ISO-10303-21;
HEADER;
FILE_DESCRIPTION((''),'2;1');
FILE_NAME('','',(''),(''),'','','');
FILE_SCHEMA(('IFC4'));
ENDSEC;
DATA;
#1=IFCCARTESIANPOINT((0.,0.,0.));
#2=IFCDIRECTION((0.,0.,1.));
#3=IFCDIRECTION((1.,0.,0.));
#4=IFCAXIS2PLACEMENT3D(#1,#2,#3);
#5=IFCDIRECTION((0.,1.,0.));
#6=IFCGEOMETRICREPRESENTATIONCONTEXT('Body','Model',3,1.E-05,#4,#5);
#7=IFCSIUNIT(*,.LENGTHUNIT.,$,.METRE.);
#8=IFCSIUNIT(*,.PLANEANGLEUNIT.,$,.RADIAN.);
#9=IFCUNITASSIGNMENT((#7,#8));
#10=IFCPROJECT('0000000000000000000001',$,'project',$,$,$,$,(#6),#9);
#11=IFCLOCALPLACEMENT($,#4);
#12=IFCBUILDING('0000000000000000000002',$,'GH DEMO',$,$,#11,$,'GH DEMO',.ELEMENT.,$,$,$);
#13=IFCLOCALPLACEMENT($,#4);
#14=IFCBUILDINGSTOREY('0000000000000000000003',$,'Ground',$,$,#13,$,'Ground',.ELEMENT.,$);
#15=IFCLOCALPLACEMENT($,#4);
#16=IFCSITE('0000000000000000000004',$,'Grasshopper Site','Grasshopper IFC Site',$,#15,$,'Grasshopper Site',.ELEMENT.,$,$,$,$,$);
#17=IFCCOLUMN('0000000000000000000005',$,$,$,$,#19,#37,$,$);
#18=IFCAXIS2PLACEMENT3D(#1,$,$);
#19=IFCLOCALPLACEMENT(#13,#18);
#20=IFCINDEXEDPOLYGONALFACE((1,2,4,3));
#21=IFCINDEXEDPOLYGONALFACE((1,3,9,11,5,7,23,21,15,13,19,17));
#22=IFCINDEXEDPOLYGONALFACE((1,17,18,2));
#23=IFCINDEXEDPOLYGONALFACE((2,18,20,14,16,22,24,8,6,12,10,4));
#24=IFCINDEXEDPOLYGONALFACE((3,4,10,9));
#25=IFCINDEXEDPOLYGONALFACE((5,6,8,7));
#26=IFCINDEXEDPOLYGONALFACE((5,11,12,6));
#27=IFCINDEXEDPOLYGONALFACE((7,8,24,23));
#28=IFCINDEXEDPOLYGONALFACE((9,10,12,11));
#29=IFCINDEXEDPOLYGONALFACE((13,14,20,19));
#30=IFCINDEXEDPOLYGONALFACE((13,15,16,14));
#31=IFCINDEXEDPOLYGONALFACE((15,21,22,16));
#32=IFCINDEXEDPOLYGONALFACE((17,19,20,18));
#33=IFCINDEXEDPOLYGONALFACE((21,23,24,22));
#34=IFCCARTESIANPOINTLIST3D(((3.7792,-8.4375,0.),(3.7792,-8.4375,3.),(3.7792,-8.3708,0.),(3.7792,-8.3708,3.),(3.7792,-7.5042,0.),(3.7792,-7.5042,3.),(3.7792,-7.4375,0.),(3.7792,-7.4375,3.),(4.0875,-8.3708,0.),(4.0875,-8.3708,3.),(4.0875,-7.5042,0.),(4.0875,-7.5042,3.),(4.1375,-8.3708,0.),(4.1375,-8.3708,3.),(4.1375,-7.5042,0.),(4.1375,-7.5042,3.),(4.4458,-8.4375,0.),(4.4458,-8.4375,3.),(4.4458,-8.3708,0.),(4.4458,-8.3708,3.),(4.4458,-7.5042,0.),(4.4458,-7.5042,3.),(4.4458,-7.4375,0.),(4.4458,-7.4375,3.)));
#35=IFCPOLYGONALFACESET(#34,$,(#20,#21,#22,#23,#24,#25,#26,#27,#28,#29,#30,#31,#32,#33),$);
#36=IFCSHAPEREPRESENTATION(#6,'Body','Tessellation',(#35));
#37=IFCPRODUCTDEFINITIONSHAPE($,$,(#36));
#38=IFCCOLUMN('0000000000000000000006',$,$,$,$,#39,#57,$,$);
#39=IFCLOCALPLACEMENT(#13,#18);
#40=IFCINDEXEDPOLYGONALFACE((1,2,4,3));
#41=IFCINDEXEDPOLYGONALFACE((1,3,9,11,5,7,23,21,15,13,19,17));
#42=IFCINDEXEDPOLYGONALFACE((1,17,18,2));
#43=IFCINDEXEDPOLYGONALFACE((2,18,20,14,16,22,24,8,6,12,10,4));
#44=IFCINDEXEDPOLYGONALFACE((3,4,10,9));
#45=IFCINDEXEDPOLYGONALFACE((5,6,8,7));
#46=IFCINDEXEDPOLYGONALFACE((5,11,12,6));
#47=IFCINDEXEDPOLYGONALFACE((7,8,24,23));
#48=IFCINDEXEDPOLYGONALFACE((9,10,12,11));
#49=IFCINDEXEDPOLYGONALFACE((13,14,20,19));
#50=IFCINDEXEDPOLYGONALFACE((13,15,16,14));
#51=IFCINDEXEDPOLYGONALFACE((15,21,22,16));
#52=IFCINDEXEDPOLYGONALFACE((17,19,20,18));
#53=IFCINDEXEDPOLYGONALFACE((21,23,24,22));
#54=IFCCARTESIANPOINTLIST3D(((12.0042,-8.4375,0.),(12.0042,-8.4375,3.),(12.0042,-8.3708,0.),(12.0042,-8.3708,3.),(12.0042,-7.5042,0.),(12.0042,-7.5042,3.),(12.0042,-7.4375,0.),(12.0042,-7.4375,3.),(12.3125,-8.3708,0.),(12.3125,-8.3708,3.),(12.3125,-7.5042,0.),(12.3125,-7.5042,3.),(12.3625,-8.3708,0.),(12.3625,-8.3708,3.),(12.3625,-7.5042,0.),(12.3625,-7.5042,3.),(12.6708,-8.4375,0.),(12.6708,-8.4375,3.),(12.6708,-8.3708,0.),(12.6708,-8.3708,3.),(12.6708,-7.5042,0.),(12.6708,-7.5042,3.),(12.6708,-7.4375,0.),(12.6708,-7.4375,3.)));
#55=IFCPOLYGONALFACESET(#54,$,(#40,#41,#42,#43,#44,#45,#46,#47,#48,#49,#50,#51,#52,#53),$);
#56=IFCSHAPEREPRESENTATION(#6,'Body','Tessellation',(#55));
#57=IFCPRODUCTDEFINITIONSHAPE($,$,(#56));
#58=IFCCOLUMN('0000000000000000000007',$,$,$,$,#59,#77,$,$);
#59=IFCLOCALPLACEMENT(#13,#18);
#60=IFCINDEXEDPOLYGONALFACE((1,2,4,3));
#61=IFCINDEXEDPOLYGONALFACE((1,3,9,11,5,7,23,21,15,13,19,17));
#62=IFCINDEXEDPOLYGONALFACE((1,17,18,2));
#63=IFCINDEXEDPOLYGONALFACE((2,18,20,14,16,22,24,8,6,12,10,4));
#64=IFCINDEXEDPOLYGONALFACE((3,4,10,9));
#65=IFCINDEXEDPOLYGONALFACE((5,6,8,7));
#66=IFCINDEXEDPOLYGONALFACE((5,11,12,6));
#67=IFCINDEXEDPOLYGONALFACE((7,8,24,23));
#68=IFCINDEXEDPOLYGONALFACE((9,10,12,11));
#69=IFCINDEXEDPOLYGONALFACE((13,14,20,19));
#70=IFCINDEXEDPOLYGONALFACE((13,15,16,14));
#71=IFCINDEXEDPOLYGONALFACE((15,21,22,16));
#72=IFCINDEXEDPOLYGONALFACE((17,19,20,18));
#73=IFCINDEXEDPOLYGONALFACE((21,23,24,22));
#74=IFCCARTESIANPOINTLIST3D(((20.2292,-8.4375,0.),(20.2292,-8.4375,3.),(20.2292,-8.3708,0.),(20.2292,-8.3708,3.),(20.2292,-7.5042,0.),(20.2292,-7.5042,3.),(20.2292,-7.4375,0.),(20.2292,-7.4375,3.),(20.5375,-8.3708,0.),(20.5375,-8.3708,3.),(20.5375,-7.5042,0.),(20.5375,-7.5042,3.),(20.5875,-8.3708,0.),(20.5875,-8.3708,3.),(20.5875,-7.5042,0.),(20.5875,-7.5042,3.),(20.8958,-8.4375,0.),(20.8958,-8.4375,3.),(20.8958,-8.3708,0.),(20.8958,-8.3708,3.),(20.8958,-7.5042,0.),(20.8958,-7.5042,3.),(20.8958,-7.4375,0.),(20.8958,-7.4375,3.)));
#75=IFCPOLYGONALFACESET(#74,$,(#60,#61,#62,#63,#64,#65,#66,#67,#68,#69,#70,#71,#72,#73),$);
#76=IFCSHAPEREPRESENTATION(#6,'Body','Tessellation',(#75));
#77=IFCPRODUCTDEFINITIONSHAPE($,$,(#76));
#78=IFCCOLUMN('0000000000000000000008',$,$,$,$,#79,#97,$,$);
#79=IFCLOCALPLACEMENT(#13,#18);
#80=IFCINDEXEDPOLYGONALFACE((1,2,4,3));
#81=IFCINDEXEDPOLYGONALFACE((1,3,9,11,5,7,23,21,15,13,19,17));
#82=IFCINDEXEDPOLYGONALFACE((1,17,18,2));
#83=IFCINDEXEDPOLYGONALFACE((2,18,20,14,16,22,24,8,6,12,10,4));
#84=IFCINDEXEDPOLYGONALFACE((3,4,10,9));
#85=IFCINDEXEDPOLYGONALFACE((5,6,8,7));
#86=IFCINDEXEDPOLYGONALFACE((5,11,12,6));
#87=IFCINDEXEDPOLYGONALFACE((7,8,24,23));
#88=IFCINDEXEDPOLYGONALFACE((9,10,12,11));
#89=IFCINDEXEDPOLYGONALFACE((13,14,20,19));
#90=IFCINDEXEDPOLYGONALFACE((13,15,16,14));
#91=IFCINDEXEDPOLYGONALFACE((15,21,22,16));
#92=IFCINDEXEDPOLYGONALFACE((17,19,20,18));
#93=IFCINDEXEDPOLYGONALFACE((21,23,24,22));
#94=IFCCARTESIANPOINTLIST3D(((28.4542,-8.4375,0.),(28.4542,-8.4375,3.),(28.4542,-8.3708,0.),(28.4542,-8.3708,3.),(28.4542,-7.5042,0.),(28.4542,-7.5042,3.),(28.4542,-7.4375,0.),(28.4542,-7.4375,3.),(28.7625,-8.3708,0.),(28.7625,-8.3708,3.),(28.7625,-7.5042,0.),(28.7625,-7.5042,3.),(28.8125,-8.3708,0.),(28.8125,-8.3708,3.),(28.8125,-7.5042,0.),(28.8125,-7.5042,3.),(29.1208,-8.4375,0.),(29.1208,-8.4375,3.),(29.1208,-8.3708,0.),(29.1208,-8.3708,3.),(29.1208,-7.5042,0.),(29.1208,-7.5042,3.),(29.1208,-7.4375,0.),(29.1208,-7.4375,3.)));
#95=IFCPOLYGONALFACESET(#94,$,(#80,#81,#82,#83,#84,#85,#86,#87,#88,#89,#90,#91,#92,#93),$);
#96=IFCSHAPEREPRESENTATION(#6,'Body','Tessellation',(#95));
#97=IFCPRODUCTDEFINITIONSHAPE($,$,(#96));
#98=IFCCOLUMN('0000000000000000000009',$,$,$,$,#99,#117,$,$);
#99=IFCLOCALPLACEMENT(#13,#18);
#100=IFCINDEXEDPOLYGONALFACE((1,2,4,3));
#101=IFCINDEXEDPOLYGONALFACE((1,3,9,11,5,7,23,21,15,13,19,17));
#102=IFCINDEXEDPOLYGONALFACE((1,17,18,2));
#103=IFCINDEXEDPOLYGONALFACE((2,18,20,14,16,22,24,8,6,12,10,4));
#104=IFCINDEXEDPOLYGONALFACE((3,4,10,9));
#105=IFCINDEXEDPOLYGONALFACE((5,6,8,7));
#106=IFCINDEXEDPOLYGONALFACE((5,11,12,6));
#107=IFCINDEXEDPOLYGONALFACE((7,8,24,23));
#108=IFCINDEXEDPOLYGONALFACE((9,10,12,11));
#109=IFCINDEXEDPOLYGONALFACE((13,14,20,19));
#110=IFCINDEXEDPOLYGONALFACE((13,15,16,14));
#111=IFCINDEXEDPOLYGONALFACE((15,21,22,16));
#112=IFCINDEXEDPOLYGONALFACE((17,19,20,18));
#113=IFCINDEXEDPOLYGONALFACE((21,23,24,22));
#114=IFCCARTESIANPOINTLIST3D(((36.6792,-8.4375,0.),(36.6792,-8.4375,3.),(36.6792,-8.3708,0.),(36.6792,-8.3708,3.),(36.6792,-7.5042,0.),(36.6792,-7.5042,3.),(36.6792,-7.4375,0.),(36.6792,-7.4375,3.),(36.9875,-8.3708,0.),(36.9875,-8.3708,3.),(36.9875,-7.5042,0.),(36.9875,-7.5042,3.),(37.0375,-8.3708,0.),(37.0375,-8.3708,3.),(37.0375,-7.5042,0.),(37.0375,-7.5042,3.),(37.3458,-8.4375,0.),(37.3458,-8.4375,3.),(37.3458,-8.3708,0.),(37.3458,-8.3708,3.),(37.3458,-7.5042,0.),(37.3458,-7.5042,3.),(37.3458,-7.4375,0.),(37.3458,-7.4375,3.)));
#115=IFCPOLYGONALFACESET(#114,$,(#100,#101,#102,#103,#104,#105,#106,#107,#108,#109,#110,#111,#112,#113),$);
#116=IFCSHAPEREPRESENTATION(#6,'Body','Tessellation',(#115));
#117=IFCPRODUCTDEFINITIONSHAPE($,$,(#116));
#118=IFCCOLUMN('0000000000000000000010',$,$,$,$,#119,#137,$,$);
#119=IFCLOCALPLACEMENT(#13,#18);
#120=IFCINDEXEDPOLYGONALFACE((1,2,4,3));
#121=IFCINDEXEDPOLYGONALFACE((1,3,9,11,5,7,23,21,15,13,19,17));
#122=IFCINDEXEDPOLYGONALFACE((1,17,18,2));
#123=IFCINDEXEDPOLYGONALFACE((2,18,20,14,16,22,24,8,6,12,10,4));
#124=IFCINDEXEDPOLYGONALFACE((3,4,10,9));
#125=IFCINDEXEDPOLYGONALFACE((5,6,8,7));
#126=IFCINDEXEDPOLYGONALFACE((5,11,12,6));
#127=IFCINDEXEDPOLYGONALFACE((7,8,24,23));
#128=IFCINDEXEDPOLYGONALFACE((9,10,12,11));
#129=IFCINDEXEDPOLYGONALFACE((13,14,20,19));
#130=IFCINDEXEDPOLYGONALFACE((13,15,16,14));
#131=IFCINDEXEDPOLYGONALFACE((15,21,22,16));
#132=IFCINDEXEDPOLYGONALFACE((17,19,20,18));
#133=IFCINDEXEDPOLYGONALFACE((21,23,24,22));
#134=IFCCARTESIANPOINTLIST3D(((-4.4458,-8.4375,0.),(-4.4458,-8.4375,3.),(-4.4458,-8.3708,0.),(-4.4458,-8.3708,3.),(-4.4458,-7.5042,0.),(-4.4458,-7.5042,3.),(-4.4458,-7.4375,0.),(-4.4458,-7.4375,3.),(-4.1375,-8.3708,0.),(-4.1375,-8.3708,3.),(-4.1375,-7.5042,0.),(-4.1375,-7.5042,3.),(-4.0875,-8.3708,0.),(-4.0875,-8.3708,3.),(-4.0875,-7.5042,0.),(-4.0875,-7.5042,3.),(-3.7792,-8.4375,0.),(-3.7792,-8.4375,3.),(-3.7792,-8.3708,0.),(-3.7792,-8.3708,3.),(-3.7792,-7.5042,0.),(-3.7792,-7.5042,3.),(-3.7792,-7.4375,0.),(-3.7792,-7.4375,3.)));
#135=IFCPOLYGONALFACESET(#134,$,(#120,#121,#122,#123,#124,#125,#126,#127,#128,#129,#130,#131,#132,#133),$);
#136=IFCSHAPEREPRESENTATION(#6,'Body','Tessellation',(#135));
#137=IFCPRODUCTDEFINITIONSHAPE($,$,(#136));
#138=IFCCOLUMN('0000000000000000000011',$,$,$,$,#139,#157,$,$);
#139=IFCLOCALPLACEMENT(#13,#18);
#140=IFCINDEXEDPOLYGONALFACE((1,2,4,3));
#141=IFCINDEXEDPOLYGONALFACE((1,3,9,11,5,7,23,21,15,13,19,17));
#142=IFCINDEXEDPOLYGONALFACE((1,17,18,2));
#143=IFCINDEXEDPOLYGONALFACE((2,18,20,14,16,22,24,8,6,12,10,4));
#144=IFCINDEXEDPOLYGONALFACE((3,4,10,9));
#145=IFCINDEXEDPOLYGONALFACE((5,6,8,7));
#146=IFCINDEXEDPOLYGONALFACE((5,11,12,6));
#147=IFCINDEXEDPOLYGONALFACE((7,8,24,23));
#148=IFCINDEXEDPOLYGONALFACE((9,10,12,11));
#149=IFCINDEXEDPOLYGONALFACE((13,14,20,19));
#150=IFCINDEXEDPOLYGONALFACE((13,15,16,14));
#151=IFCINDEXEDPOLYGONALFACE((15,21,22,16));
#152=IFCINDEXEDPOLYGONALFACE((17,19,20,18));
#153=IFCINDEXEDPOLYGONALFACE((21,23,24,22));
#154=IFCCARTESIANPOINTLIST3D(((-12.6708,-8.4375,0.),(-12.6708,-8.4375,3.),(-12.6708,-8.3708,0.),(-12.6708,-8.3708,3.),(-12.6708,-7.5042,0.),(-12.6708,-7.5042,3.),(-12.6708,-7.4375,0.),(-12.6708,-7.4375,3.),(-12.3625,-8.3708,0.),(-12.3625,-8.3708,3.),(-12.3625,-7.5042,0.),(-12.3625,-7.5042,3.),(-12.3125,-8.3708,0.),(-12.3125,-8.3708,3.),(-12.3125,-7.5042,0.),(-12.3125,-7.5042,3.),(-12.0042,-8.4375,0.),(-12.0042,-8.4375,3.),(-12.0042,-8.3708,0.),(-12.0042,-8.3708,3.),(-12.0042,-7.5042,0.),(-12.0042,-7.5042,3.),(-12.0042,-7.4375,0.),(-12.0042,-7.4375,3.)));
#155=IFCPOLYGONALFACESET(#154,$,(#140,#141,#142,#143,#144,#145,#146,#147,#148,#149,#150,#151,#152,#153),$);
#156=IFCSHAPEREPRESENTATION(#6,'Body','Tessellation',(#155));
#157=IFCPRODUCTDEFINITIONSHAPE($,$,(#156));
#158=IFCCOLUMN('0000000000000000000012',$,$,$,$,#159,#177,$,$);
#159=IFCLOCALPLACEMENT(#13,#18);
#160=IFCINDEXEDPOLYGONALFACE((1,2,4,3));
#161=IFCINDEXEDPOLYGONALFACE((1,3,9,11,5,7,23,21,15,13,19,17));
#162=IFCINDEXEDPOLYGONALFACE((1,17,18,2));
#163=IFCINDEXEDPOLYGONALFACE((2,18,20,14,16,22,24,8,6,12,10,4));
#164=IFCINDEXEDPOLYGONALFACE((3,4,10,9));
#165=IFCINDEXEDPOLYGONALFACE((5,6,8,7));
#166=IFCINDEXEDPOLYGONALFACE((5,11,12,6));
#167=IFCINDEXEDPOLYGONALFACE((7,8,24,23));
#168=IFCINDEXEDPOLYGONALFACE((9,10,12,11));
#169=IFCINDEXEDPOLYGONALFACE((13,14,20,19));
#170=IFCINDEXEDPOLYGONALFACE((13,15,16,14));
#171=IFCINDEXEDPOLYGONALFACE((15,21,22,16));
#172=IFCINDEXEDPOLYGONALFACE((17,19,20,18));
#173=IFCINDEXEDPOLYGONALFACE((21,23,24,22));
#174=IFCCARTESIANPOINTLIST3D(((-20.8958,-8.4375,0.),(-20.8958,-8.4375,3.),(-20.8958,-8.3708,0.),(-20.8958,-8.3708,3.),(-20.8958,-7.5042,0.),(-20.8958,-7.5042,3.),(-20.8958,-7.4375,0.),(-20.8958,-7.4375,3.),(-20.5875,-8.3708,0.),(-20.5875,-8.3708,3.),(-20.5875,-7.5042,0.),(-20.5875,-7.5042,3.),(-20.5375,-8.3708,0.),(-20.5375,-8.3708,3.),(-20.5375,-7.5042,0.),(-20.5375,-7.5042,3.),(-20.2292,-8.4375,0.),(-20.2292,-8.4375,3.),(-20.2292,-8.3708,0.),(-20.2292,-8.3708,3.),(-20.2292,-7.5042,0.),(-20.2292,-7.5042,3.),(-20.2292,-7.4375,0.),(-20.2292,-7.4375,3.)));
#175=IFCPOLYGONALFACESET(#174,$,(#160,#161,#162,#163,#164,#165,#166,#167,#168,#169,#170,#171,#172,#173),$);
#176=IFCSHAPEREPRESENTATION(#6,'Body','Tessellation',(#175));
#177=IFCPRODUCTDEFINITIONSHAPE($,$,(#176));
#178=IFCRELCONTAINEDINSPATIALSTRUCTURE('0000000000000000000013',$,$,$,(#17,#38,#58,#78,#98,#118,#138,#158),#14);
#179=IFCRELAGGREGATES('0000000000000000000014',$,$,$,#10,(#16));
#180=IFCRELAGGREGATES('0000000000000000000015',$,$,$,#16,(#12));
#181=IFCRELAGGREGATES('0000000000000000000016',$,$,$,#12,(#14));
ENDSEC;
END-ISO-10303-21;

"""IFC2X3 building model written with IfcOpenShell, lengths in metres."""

from ifc_helpers import new_model, si_unit, direction, origin_with_axes, place, context, project, spatial, polyline, outline, extrude, source, transform, mapped, element, save


model = new_model("IFC2X3")

# Units and contexts
model_context = context("Model", 3, precision=1e-05, world=origin_with_axes(), true_north=direction((0.0, 1.0, 0.0)), identifier="Body")
ifc_project = project(units=[si_unit("LENGTHUNIT", "METRE"), si_unit("PLANEANGLEUNIT", "RADIAN")], contexts=[model_context])

# Site, building, storey
site_placement = place(None, origin_with_axes())
site = spatial("IfcSite", under=ifc_project, at=site_placement, Name="Grasshopper Site", Description="Grasshopper IFC Site", LongName="Grasshopper Site", CompositionType="ELEMENT")
building_placement = place(None, origin_with_axes())
building = spatial("IfcBuilding", under=site, at=building_placement, Name="GH DEMO", LongName="GH DEMO", CompositionType="ELEMENT")
storey_placement = place(None, origin_with_axes())
storey = spatial("IfcBuildingStorey", under=building, at=storey_placement, Name="Ground", LongName="Ground", CompositionType="ELEMENT")

# Columns
shared_shape_1 = source(origin_with_axes(), model_context, "Body", "SweptSolid", [
    extrude(outline(polyline([(0.025, -0.4333), (0.025, 0.4333), (0.3333, 0.4333), (0.3333, 0.5), (-0.3333, 0.5), (-0.3333, 0.4333), (-0.025, 0.4333), (-0.025, -0.4333), (-0.3333, -0.4333), (-0.3333, -0.5), (0.3333, -0.5), (0.3333, -0.4333), (0.025, -0.4333)])), origin_with_axes(), (0.0, 0.0, 1.0), 3.0),
])
column_1_placement = place(None, origin_with_axes())
element("IfcColumn", 1, at=column_1_placement, inside=storey, context=model_context, shape_type="MappedRepresentation", body=[
    mapped(shared_shape_1, transform((4.1125, -7.9375, 0.0), x_axis=(1.0, 0.0, 0.0), y_axis=(0.0, 1.0, 0.0), z_axis=(0.0, 0.0, 1.0), scale=1.0)),
])
shared_shape_2 = source(origin_with_axes(), model_context, "Body", "SweptSolid", [
    extrude(outline(polyline([(0.025, -0.4333), (0.025, 0.4333), (0.3333, 0.4333), (0.3333, 0.5), (-0.3333, 0.5), (-0.3333, 0.4333), (-0.025, 0.4333), (-0.025, -0.4333), (-0.3333, -0.4333), (-0.3333, -0.5), (0.3333, -0.5), (0.3333, -0.4333), (0.025, -0.4333)])), origin_with_axes(), (0.0, 0.0, 1.0), 3.0),
])
column_2_placement = place(None, origin_with_axes())
element("IfcColumn", 2, at=column_2_placement, inside=storey, context=model_context, shape_type="MappedRepresentation", body=[
    mapped(shared_shape_2, transform((12.3375, -7.9375, 0.0), x_axis=(1.0, 0.0, 0.0), y_axis=(0.0, 1.0, 0.0), z_axis=(0.0, 0.0, 1.0), scale=1.0)),
])
shared_shape_3 = source(origin_with_axes(), model_context, "Body", "SweptSolid", [
    extrude(outline(polyline([(0.025, -0.4333), (0.025, 0.4333), (0.3333, 0.4333), (0.3333, 0.5), (-0.3333, 0.5), (-0.3333, 0.4333), (-0.025, 0.4333), (-0.025, -0.4333), (-0.3333, -0.4333), (-0.3333, -0.5), (0.3333, -0.5), (0.3333, -0.4333), (0.025, -0.4333)])), origin_with_axes(), (0.0, 0.0, 1.0), 3.0),
])
column_3_placement = place(None, origin_with_axes())
element("IfcColumn", 3, at=column_3_placement, inside=storey, context=model_context, shape_type="MappedRepresentation", body=[
    mapped(shared_shape_3, transform((20.5625, -7.9375, 0.0), x_axis=(1.0, 0.0, 0.0), y_axis=(0.0, 1.0, 0.0), z_axis=(0.0, 0.0, 1.0), scale=1.0)),
])
shared_shape_4 = source(origin_with_axes(), model_context, "Body", "SweptSolid", [
    extrude(outline(polyline([(0.025, -0.4333), (0.025, 0.4333), (0.3333, 0.4333), (0.3333, 0.5), (-0.3333, 0.5), (-0.3333, 0.4333), (-0.025, 0.4333), (-0.025, -0.4333), (-0.3333, -0.4333), (-0.3333, -0.5), (0.3333, -0.5), (0.3333, -0.4333), (0.025, -0.4333)])), origin_with_axes(), (0.0, 0.0, 1.0), 3.0),
])
column_4_placement = place(None, origin_with_axes())
element("IfcColumn", 4, at=column_4_placement, inside=storey, context=model_context, shape_type="MappedRepresentation", body=[
    mapped(shared_shape_4, transform((28.7875, -7.9375, 0.0), x_axis=(1.0, 0.0, 0.0), y_axis=(0.0, 1.0, 0.0), z_axis=(0.0, 0.0, 1.0), scale=1.0)),
])
shared_shape_5 = source(origin_with_axes(), model_context, "Body", "SweptSolid", [
    extrude(outline(polyline([(0.025, -0.4333), (0.025, 0.4333), (0.3333, 0.4333), (0.3333, 0.5), (-0.3333, 0.5), (-0.3333, 0.4333), (-0.025, 0.4333), (-0.025, -0.4333), (-0.3333, -0.4333), (-0.3333, -0.5), (0.3333, -0.5), (0.3333, -0.4333), (0.025, -0.4333)])), origin_with_axes(), (0.0, 0.0, 1.0), 3.0),
])
column_5_placement = place(None, origin_with_axes())
element("IfcColumn", 5, at=column_5_placement, inside=storey, context=model_context, shape_type="MappedRepresentation", body=[
    mapped(shared_shape_5, transform((37.0125, -7.9375, 0.0), x_axis=(1.0, 0.0, 0.0), y_axis=(0.0, 1.0, 0.0), z_axis=(0.0, 0.0, 1.0), scale=1.0)),
])
shared_shape_6 = source(origin_with_axes(), model_context, "Body", "SweptSolid", [
    extrude(outline(polyline([(0.025, -0.4333), (0.025, 0.4333), (0.3333, 0.4333), (0.3333, 0.5), (-0.3333, 0.5), (-0.3333, 0.4333), (-0.025, 0.4333), (-0.025, -0.4333), (-0.3333, -0.4333), (-0.3333, -0.5), (0.3333, -0.5), (0.3333, -0.4333), (0.025, -0.4333)])), origin_with_axes(), (0.0, 0.0, 1.0), 3.0),
])
column_6_placement = place(None, origin_with_axes())
element("IfcColumn", 6, at=column_6_placement, inside=storey, context=model_context, shape_type="MappedRepresentation", body=[
    mapped(shared_shape_6, transform((-4.1125, -7.9375, 0.0), x_axis=(1.0, 0.0, 0.0), y_axis=(0.0, 1.0, 0.0), z_axis=(0.0, 0.0, 1.0), scale=1.0)),
])
shared_shape_7 = source(origin_with_axes(), model_context, "Body", "SweptSolid", [
    extrude(outline(polyline([(0.025, -0.4333), (0.025, 0.4333), (0.3333, 0.4333), (0.3333, 0.5), (-0.3333, 0.5), (-0.3333, 0.4333), (-0.025, 0.4333), (-0.025, -0.4333), (-0.3333, -0.4333), (-0.3333, -0.5), (0.3333, -0.5), (0.3333, -0.4333), (0.025, -0.4333)])), origin_with_axes(), (0.0, 0.0, 1.0), 3.0),
])
column_7_placement = place(None, origin_with_axes())
element("IfcColumn", 7, at=column_7_placement, inside=storey, context=model_context, shape_type="MappedRepresentation", body=[
    mapped(shared_shape_7, transform((-12.3375, -7.9375, 0.0), x_axis=(1.0, 0.0, 0.0), y_axis=(0.0, 1.0, 0.0), z_axis=(0.0, 0.0, 1.0), scale=1.0)),
])
shared_shape_8 = source(origin_with_axes(), model_context, "Body", "SweptSolid", [
    extrude(outline(polyline([(0.025, -0.4333), (0.025, 0.4333), (0.3333, 0.4333), (0.3333, 0.5), (-0.3333, 0.5), (-0.3333, 0.4333), (-0.025, 0.4333), (-0.025, -0.4333), (-0.3333, -0.4333), (-0.3333, -0.5), (0.3333, -0.5), (0.3333, -0.4333), (0.025, -0.4333)])), origin_with_axes(), (0.0, 0.0, 1.0), 3.0),
])
column_8_placement = place(None, origin_with_axes())
element("IfcColumn", 8, at=column_8_placement, inside=storey, context=model_context, shape_type="MappedRepresentation", body=[
    mapped(shared_shape_8, transform((-20.5625, -7.9375, 0.0), x_axis=(1.0, 0.0, 0.0), y_axis=(0.0, 1.0, 0.0), z_axis=(0.0, 0.0, 1.0), scale=1.0)),
])

save(model, "model.ifc")
